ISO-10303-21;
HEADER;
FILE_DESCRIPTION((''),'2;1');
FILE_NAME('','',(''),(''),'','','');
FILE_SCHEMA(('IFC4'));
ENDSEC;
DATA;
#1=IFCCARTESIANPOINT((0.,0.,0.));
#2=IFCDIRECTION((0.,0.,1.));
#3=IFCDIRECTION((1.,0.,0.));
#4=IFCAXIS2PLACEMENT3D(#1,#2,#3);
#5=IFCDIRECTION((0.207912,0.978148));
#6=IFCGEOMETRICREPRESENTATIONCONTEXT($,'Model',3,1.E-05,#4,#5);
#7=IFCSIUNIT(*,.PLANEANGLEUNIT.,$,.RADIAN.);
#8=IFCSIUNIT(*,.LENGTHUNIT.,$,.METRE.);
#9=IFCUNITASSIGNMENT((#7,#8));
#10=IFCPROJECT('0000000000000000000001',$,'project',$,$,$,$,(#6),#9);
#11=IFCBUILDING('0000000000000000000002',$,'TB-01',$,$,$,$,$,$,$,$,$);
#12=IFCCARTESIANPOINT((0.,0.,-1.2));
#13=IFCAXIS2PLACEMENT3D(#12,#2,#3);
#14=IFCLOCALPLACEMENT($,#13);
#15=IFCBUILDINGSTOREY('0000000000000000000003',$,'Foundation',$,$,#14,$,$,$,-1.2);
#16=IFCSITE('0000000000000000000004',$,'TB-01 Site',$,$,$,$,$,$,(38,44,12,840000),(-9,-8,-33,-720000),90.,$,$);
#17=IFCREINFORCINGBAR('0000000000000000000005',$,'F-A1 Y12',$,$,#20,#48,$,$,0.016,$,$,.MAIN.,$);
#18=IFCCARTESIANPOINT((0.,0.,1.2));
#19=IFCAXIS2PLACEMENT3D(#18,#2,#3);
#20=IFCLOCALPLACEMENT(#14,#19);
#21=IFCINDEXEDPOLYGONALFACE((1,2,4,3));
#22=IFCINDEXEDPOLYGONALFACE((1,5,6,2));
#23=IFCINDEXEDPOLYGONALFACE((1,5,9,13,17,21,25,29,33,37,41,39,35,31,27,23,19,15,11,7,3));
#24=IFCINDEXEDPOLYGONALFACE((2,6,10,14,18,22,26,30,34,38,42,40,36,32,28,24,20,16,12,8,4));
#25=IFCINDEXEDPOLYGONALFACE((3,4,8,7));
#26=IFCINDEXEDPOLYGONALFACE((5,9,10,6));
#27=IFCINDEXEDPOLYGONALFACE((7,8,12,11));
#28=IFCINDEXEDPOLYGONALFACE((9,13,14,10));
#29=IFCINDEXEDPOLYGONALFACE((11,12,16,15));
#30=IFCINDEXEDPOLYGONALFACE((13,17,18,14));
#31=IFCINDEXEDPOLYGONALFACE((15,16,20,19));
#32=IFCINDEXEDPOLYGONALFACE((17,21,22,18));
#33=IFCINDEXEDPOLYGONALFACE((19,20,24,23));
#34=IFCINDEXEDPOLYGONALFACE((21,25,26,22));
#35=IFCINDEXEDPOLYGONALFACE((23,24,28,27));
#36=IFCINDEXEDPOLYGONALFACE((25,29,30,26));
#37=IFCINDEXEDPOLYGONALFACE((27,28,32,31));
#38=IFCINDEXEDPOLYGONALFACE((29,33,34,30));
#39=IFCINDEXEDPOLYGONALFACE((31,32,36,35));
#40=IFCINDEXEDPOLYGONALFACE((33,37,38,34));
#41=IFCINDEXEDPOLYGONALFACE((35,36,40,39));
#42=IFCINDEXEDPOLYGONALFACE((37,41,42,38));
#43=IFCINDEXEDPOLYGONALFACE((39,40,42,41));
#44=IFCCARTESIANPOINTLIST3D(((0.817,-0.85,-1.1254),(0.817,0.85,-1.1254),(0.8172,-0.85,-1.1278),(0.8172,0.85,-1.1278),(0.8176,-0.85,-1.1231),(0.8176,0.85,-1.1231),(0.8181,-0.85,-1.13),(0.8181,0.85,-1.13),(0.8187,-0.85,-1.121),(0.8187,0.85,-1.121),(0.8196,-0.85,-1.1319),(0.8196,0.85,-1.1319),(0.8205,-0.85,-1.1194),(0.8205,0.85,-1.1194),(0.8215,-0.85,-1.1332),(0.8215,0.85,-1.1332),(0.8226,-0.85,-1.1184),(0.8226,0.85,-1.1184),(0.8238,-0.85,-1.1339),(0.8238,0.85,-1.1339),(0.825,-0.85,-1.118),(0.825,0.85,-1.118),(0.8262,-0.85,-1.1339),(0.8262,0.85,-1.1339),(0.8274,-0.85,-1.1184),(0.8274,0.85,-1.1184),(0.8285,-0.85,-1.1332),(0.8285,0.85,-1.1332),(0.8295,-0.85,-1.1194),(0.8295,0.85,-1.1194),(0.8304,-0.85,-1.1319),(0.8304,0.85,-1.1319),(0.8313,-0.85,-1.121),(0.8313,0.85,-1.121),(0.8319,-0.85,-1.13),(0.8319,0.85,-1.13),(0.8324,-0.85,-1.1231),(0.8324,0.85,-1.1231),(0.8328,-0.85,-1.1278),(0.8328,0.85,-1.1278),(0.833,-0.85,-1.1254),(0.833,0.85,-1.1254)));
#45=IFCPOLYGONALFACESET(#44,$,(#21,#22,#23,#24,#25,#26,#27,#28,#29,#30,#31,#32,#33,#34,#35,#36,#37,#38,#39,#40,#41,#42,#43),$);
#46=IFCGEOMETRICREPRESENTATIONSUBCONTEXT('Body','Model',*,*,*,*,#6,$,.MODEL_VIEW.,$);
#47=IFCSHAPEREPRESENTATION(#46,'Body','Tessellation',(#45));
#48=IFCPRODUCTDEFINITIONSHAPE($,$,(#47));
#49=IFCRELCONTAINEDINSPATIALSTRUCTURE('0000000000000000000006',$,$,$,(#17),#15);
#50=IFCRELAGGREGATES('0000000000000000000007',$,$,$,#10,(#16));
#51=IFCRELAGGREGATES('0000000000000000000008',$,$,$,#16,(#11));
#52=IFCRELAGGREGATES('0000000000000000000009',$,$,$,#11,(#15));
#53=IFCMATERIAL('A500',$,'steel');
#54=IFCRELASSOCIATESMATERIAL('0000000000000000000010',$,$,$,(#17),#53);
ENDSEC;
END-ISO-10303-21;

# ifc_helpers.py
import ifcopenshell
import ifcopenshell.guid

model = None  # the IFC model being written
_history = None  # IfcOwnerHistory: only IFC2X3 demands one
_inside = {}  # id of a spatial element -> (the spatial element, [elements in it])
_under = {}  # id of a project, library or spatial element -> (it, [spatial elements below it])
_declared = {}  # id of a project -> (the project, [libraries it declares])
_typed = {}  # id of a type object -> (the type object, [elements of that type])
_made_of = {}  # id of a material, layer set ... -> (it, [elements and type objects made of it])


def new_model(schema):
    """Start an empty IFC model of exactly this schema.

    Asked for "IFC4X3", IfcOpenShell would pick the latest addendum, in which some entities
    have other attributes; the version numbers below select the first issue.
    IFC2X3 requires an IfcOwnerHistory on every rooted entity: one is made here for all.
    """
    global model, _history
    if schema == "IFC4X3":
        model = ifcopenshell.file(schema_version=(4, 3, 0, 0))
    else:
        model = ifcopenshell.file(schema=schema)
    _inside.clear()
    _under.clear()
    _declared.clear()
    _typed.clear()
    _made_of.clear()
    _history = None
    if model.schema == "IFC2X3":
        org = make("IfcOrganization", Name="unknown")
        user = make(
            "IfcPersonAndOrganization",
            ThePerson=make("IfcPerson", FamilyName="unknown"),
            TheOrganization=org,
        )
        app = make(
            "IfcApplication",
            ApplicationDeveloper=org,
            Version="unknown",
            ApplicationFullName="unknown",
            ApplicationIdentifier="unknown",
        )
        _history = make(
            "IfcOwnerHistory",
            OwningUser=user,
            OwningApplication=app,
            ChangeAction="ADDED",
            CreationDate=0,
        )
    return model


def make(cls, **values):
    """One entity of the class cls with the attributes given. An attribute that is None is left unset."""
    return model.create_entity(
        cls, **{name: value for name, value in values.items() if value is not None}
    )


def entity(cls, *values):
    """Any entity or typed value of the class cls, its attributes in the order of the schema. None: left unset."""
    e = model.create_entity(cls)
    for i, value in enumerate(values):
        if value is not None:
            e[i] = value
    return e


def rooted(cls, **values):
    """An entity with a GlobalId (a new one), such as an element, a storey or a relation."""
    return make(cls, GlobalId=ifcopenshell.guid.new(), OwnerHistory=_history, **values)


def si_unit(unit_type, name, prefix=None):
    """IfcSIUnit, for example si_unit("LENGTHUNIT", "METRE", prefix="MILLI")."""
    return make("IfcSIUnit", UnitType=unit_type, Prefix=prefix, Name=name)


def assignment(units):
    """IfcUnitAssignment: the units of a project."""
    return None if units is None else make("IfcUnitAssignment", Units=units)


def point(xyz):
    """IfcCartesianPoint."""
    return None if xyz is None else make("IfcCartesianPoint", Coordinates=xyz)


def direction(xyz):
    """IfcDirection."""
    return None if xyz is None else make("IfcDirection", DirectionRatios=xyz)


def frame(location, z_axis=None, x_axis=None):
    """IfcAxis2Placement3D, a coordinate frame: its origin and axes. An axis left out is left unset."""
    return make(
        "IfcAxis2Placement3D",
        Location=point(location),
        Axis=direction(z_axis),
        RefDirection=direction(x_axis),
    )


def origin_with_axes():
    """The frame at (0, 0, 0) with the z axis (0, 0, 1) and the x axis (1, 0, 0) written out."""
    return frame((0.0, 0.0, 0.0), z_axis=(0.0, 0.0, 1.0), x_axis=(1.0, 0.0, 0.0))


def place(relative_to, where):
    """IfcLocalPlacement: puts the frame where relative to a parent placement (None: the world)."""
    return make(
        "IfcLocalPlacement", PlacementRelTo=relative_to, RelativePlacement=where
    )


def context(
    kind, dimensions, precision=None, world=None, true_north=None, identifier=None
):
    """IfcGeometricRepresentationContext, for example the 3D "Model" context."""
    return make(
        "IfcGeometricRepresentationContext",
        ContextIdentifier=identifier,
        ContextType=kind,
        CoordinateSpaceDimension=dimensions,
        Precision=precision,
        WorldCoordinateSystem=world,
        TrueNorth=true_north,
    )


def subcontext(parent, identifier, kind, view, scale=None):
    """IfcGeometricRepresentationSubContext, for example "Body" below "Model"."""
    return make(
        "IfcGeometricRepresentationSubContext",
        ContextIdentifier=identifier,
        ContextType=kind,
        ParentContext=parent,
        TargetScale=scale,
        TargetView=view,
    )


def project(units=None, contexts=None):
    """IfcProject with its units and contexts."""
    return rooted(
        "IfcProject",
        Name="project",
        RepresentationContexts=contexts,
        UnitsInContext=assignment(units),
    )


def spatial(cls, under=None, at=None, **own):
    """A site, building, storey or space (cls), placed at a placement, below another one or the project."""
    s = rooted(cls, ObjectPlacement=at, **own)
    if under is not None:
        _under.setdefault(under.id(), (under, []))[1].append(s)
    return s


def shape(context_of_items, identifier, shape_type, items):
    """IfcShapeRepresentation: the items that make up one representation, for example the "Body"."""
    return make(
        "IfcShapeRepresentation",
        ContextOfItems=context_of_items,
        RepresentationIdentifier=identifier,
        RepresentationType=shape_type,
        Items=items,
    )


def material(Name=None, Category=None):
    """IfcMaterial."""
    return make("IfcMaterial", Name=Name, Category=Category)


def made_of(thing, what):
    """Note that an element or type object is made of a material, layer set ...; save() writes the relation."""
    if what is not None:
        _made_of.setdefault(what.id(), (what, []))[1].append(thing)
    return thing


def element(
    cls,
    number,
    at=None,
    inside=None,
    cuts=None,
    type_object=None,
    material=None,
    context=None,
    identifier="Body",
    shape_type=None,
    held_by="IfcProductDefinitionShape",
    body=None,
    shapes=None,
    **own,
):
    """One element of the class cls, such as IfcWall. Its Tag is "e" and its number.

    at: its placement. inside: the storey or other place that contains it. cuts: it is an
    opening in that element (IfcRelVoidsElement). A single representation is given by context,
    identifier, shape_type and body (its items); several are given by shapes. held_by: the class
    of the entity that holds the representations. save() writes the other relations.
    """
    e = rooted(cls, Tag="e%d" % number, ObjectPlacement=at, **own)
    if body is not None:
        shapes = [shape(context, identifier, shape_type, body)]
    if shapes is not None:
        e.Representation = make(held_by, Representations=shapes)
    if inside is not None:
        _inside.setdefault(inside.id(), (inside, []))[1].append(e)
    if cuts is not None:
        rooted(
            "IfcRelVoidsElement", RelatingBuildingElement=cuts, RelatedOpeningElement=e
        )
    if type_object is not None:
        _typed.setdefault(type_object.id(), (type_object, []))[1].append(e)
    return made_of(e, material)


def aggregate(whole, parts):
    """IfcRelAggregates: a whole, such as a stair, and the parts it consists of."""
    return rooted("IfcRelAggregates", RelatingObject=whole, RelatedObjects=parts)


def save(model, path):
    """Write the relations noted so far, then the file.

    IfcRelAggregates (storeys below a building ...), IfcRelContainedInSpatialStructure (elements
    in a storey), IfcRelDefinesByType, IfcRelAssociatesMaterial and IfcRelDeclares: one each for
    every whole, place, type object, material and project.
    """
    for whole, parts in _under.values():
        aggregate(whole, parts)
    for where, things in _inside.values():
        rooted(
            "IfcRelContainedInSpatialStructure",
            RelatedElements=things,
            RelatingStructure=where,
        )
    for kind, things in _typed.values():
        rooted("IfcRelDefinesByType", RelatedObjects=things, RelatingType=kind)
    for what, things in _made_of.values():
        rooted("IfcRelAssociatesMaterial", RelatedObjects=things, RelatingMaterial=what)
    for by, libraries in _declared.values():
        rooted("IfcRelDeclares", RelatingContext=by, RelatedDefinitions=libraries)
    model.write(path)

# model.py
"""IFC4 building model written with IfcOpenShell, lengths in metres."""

from ifc_helpers import new_model, entity, si_unit, direction, frame, origin_with_axes, place, context, subcontext, project, spatial, material, element, save


model = new_model("IFC4")

# Units and contexts
model_context = context("Model", 3, precision=1e-05, world=origin_with_axes(), true_north=direction((0.207912, 0.978148)))
body_context = subcontext(model_context, "Body", "Model", "MODEL_VIEW")
ifc_project = project(units=[si_unit("PLANEANGLEUNIT", "RADIAN"), si_unit("LENGTHUNIT", "METRE")], contexts=[model_context])

# Site, building, storey
site = spatial("IfcSite", under=ifc_project, Name="TB-01 Site", RefLatitude=(38, 44, 12, 840000), RefLongitude=(-9, -8, -33, -720000), RefElevation=90.0)
building = spatial("IfcBuilding", under=site, Name="TB-01")
storey_placement = place(None, frame((0.0, 0.0, -1.2), z_axis=(0.0, 0.0, 1.0), x_axis=(1.0, 0.0, 0.0)))
storey = spatial("IfcBuildingStorey", under=building, at=storey_placement, Name="Foundation", Elevation=-1.2)

# Reinforcing bar
ifc_material_1 = material(Name="A500", Category="steel")
reinforcing_bar_1_placement = place(storey_placement, frame((0.0, 0.0, 1.2), z_axis=(0.0, 0.0, 1.0), x_axis=(1.0, 0.0, 0.0)))
element("IfcReinforcingBar", 1, at=reinforcing_bar_1_placement, inside=storey, material=ifc_material_1, Name="F-A1 Y12", NominalDiameter=0.016, PredefinedType="MAIN", context=body_context, shape_type="AdvancedSweptSolid", body=[
    entity("IfcSweptDiskSolid", entity("IfcPolyline", [entity("IfcCartesianPoint", [0.825, -0.85, -1.126]), entity("IfcCartesianPoint", [0.825, 0.85, -1.126])]), 0.008),
])

save(model, "model.ifc")
